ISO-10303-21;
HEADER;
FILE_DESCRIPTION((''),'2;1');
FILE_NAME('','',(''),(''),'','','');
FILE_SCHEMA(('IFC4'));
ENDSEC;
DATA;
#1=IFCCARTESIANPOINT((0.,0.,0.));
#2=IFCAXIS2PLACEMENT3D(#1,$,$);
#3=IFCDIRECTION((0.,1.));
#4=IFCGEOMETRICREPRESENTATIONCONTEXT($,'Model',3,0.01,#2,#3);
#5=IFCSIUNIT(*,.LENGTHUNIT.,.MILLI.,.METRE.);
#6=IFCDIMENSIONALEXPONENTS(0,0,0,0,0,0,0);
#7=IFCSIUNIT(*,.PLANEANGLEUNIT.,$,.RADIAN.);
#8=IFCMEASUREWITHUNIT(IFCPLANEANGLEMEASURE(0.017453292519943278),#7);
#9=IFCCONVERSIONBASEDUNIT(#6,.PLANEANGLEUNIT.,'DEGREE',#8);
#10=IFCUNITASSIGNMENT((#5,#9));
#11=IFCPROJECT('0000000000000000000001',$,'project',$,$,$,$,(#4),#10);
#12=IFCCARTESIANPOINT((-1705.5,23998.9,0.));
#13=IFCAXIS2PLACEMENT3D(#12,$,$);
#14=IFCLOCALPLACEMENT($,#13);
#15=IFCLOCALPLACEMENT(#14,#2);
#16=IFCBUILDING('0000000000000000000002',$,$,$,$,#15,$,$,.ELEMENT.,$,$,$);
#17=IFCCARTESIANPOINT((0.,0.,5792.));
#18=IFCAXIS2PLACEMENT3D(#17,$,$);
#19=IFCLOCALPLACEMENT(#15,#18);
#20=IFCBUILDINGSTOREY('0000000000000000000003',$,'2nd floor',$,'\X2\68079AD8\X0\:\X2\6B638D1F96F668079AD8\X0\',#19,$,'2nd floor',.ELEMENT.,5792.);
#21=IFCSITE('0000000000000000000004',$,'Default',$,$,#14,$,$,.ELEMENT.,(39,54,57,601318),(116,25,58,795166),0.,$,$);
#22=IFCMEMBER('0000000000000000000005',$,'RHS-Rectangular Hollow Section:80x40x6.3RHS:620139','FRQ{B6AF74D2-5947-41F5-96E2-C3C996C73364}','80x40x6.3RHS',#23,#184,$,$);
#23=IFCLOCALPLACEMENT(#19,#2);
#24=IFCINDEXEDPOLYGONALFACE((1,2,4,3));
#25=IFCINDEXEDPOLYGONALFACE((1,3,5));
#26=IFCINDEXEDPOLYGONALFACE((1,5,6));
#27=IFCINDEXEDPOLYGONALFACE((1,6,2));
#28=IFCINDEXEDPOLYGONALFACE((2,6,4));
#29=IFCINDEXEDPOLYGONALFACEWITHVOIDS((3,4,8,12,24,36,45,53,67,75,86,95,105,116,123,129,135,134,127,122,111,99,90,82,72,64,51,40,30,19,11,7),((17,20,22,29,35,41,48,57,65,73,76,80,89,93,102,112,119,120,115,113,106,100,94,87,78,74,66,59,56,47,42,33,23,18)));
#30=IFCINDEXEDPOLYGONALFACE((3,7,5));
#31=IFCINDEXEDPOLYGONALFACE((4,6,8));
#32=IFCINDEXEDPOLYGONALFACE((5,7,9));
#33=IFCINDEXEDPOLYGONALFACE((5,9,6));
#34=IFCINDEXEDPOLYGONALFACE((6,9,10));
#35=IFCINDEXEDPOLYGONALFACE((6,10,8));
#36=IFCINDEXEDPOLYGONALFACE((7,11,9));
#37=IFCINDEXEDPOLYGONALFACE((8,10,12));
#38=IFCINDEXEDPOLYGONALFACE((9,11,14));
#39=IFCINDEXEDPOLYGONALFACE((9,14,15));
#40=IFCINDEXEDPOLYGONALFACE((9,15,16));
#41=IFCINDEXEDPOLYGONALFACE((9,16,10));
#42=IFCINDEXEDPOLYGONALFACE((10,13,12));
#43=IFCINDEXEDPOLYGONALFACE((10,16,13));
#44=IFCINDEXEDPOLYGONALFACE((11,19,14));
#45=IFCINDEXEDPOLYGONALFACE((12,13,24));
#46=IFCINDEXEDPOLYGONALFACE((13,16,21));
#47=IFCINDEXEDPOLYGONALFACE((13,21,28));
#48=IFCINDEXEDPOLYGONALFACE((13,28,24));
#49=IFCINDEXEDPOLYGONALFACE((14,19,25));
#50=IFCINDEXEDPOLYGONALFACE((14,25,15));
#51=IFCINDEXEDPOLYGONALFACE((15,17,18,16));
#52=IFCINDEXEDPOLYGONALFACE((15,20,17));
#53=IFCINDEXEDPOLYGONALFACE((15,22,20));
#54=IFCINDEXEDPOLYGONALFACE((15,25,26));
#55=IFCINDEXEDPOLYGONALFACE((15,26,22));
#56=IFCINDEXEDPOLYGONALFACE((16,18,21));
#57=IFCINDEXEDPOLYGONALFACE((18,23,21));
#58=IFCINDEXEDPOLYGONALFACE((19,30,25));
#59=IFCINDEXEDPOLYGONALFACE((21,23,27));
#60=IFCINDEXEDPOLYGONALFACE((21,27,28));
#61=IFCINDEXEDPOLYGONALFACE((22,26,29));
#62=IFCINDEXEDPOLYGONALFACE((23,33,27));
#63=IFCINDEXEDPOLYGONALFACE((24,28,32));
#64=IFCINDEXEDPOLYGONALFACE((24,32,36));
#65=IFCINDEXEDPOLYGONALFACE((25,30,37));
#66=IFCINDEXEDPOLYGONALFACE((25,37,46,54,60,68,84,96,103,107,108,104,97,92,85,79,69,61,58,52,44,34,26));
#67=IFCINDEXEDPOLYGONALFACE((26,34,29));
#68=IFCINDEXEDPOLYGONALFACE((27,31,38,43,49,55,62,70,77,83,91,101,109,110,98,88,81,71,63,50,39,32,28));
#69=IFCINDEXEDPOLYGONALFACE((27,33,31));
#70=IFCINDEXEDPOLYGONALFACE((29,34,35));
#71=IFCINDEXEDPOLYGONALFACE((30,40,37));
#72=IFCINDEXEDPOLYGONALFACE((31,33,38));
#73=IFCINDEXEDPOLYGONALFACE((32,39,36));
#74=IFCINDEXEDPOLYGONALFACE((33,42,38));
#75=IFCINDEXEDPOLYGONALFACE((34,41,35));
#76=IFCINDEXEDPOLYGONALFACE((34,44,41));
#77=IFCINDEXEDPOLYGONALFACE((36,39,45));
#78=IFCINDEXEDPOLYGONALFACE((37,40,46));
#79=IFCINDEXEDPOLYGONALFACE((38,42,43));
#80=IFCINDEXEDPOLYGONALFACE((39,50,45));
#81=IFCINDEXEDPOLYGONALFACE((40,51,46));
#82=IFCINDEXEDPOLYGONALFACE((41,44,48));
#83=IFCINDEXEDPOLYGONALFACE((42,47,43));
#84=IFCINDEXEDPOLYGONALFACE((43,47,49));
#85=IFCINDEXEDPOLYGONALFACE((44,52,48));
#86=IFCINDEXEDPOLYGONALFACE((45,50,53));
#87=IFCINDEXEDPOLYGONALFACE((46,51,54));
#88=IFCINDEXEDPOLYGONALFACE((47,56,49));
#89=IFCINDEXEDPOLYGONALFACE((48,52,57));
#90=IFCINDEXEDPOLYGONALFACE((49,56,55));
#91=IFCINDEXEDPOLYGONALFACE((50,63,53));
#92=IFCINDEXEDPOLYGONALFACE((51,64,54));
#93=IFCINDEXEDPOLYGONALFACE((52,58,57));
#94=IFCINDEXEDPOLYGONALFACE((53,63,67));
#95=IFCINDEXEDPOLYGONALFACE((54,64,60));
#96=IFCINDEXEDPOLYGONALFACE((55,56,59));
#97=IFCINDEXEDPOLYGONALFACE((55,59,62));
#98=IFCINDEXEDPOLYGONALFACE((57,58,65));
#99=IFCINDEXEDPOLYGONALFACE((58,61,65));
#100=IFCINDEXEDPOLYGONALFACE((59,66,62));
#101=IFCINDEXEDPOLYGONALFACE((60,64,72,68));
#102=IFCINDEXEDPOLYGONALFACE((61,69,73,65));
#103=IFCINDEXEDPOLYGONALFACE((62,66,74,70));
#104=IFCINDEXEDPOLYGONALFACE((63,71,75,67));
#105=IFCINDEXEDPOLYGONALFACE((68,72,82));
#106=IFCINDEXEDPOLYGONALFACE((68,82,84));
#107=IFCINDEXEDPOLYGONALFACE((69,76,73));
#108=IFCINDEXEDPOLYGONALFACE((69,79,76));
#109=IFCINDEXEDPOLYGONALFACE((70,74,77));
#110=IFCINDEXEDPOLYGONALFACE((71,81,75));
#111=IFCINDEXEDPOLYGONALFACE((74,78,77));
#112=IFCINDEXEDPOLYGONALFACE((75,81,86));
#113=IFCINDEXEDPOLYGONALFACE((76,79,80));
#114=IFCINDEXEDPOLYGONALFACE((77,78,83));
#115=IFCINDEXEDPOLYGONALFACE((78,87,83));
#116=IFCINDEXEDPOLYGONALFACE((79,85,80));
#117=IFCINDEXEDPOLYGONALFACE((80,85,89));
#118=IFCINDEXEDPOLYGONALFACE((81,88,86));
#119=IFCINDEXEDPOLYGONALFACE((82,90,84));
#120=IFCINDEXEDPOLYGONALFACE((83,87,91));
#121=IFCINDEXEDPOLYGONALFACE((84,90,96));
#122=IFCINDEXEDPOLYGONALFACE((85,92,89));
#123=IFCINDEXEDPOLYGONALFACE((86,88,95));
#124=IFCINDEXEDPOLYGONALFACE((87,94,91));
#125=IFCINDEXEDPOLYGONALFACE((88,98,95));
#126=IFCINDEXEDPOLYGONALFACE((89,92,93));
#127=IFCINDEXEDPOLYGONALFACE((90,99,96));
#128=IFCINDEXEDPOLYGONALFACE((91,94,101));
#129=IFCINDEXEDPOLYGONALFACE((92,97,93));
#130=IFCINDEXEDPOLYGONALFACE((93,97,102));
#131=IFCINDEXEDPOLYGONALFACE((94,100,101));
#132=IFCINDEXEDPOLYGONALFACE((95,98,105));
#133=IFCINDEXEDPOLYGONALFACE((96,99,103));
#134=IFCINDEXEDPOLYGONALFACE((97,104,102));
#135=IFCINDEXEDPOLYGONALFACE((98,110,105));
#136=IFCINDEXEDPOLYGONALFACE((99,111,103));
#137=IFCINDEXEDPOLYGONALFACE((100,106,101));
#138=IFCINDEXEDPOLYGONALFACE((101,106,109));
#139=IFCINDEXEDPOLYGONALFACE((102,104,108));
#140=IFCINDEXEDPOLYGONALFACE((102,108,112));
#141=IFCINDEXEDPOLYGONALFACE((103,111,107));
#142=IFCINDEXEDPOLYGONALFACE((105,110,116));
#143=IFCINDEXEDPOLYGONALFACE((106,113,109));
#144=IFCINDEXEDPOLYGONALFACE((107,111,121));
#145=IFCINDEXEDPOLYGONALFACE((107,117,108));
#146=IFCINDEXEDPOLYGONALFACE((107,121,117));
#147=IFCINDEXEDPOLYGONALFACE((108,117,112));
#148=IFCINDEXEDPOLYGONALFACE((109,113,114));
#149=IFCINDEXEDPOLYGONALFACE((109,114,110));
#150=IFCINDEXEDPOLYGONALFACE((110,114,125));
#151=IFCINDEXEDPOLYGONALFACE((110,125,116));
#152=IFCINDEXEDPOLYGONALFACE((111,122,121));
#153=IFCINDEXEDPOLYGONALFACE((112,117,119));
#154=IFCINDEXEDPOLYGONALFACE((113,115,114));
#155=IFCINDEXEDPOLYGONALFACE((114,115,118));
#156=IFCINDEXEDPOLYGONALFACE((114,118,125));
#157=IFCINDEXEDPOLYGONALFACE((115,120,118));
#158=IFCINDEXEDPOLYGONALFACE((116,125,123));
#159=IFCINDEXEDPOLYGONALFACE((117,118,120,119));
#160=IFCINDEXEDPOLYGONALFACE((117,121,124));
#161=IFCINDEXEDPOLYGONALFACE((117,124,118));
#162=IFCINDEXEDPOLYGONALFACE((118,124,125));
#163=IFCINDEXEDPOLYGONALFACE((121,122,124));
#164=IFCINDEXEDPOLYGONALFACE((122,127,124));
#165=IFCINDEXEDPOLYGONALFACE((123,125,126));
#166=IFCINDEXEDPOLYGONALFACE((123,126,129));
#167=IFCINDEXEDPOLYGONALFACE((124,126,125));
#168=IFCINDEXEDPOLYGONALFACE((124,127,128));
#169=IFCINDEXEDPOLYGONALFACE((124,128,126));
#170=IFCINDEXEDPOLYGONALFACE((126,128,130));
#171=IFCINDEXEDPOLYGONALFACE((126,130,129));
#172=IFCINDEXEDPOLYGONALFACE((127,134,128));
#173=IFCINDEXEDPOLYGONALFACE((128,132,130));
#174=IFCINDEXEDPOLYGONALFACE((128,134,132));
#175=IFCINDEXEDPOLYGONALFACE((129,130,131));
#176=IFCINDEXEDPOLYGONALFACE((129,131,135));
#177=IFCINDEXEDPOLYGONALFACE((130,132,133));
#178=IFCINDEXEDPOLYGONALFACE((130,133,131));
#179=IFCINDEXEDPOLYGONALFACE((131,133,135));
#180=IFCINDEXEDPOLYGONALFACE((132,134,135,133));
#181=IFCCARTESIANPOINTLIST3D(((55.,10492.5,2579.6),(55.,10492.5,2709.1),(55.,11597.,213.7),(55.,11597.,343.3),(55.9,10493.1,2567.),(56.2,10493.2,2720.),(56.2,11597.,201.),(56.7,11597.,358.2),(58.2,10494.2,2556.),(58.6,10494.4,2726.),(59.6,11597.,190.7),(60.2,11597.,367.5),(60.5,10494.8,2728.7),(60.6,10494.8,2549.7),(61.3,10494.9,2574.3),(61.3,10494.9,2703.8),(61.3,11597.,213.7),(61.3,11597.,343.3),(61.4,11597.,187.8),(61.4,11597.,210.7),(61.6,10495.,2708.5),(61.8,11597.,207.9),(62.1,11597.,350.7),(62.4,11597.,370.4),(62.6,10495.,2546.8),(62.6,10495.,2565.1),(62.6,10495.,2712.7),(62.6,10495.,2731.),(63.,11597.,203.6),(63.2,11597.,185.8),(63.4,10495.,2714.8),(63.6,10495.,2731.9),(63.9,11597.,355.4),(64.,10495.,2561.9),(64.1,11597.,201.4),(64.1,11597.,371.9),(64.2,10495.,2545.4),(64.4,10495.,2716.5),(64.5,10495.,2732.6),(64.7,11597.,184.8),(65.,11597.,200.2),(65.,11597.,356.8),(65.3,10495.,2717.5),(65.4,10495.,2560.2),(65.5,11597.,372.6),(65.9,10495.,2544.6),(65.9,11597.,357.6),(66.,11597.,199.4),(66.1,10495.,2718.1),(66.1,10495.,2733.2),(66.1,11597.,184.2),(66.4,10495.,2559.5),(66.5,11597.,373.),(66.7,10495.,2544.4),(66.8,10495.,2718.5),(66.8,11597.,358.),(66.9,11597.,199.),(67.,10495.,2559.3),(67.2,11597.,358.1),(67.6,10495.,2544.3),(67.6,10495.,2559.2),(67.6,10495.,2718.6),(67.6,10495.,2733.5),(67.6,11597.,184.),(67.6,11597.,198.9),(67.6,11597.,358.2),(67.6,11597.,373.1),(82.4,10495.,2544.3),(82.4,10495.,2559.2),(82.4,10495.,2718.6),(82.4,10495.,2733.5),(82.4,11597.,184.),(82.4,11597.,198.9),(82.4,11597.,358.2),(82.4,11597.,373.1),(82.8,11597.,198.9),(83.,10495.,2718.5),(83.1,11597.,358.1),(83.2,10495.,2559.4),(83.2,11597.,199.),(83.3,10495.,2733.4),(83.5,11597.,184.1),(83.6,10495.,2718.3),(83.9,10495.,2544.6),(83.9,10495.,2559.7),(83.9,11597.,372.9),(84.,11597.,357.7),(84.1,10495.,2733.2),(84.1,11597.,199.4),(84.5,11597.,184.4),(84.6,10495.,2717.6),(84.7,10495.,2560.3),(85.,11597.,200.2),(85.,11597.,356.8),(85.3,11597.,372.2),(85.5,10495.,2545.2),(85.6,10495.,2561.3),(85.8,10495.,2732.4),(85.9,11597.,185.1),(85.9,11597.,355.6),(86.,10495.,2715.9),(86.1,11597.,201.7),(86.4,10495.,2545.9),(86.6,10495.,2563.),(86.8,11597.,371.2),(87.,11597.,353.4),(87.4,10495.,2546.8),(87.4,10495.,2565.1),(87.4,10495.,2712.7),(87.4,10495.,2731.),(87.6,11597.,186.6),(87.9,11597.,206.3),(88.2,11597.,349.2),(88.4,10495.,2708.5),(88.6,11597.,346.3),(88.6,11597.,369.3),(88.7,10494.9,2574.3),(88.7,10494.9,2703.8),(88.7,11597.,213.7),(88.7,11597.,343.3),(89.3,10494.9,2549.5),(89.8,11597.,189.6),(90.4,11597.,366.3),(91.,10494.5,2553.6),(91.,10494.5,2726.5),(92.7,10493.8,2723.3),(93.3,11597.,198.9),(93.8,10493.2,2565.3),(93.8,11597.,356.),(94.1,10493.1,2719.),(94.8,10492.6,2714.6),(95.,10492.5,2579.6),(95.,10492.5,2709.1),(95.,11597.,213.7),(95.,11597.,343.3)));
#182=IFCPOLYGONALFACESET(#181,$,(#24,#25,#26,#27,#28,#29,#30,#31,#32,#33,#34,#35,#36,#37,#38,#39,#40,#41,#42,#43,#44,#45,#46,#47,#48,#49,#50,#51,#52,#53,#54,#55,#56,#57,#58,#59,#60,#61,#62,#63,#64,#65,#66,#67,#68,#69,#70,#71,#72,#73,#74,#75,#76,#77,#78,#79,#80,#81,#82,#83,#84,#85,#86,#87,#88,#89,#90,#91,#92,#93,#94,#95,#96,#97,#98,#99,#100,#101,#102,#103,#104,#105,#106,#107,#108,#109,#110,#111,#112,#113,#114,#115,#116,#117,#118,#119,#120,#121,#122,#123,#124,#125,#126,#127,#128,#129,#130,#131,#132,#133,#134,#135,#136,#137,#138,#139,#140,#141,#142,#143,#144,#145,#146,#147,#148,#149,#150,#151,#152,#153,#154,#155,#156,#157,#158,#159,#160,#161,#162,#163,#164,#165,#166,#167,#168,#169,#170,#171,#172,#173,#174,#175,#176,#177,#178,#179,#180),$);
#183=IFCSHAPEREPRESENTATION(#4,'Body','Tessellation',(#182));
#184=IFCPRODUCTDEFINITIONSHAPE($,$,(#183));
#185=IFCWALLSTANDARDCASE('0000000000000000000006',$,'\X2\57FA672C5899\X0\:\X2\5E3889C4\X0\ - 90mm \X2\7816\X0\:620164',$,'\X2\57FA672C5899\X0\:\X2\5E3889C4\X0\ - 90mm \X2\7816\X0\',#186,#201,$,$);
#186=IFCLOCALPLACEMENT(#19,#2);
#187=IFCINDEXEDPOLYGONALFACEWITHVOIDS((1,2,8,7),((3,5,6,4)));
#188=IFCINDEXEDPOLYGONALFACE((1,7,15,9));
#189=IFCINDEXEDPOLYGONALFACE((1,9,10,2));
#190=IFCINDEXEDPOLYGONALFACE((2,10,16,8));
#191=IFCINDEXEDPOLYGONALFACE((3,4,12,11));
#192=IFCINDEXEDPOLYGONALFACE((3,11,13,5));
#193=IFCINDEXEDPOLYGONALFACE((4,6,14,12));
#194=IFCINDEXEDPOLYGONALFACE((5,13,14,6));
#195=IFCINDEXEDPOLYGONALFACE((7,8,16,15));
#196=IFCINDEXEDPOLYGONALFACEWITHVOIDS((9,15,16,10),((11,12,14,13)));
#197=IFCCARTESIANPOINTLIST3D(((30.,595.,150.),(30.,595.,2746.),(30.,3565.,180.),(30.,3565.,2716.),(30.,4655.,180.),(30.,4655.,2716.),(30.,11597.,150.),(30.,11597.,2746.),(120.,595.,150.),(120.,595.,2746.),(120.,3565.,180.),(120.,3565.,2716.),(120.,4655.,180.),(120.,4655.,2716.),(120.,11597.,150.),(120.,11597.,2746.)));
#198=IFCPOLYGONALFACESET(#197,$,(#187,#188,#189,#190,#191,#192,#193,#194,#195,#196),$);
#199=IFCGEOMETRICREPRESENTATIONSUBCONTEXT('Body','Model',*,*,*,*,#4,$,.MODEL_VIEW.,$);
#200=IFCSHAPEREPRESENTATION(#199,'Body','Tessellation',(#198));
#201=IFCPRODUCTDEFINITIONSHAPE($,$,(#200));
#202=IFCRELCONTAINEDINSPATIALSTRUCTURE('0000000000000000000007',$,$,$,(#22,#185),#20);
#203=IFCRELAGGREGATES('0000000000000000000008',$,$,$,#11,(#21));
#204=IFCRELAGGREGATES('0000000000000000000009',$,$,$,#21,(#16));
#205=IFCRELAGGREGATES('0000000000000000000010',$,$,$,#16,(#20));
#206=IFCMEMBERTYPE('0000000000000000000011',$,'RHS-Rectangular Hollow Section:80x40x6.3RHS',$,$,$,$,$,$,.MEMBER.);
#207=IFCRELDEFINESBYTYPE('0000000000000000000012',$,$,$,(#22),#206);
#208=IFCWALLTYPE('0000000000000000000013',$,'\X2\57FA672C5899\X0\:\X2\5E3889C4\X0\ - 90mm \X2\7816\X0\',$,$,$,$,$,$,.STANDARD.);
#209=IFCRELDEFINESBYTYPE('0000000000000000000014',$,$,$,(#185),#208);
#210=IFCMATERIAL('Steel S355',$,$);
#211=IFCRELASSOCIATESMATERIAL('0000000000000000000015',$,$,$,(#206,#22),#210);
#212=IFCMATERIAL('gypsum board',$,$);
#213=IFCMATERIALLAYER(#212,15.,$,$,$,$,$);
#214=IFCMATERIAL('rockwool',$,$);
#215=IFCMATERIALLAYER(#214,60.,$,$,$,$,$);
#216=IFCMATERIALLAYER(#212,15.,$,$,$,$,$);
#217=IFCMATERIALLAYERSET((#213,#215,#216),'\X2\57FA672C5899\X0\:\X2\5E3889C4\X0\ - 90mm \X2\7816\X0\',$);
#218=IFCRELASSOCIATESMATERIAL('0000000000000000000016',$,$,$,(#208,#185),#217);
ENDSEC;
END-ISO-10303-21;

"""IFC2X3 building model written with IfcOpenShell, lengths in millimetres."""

from ifc_helpers import new_model, entity, si_unit, converted_unit, point, direction, frame, frame_2d, origin, origin_2d, place, context, subcontext, project, spatial, circle_curve, line_curve, trimmed, segment, composite_curve, rectangle, hollow_rectangle, outline, extrude, clip, halfspace, material, layer, layer_set, layer_usage, type_object, element, save


model = new_model("IFC2X3")

# Units and contexts
model_context = context("Model", 3, precision=0.01, world=origin(), true_north=direction((0.0, 1.0)))
body_context = subcontext(model_context, "Body", "Model", "MODEL_VIEW")
ifc_project = project(units=[si_unit("LENGTHUNIT", "METRE", prefix="MILLI"), converted_unit("PLANEANGLEUNIT", "DEGREE", entity("IfcPlaneAngleMeasure", 0.017453292519943278), si_unit("PLANEANGLEUNIT", "RADIAN"), dimensions=[0, 0, 0, 0, 0, 0, 0])], contexts=[model_context])

# Site, building, storey
site_placement = place(None, frame((-1705.5, 23998.9, 0.0)))
site = spatial("IfcSite", under=ifc_project, at=site_placement, Name="Default", CompositionType="ELEMENT", RefLatitude=(39, 54, 57, 601318), RefLongitude=(116, 25, 58, 795166), RefElevation=0.0)
building_placement = place(site_placement, origin())
building = spatial("IfcBuilding", under=site, at=building_placement, CompositionType="ELEMENT")
storey_placement = place(building_placement, frame((0.0, 0.0, 5792.0)))
storey = spatial("IfcBuildingStorey", under=building, at=storey_placement, Name="2nd floor", ObjectType="标高:正负零标高", LongName="2nd floor", CompositionType="ELEMENT", Elevation=5792.0)

# Shared definitions
ifc_material_1 = material(Name="Steel S355")

# Member, openings
member_type_1 = type_object("IfcMemberType", Name="RHS-Rectangular Hollow Section:80x40x6.3RHS", PredefinedType="MEMBER", material=ifc_material_1)
member_1_placement = place(storey_placement, frame((75.0, 11701.7, 54.2), z_axis=(0.0, 0.423038, -0.906112), x_axis=(-1.0, 0.0, 0.0)))
member_1 = element("IfcMember", 1, at=member_1_placement, inside=storey, type_object=member_type_1, material=ifc_material_1, Name="RHS-Rectangular Hollow Section:80x40x6.3RHS:620139", Description="FRQ{B6AF74D2-5947-41F5-96E2-C3C996C73364}", ObjectType="80x40x6.3RHS", context=model_context, shape_type="Clipping", body=[
    clip(clip(extrude(hollow_rectangle(XDim=40.0, YDim=80.0, WallThickness=6.3, InnerFilletRadius=6.3, OuterFilletRadius=12.6, at=origin_2d()), origin(), (0.0, 0.0, -1.0), 3076.4), halfspace(frame((75.0, -2513.7, 5278.4), z_axis=(0.0, -0.906112, -0.423038), x_axis=(-1.0, 0.0, 0.0)), True)), halfspace(frame((75.0, -3611.9, 4765.7), z_axis=(0.0, 0.906112, 0.423038), x_axis=(1.0, 0.0, 0.0)), True)),
])
opening_1_placement = place(member_1_placement, frame((0.0, -82.3, 70.7), z_axis=(0.0, 0.423038, -0.906112), x_axis=(-1.0, 0.0, 0.0)))
element("IfcOpeningElement", 2, at=opening_1_placement, cuts=member_1, ObjectType="Opening", context=model_context, shape_type="SweptSolid", body=[
    extrude(outline(composite_curve([segment(trimmed(circle_curve(frame_2d((-40.0, -40.0), x_axis=(1.0, 0.0)), 20.0), [point((-60.0, -40.0))], [point((-40.0, -60.0))], True, "CARTESIAN"), True, "CONTINUOUS"), segment(trimmed(line_curve((-40.0, -60.0), (1.0, 0.0), 79.999999), [point((-40.0, -60.0))], [point((40.0, -60.0))], True, "CARTESIAN"), True, "CONTINUOUS"), segment(trimmed(circle_curve(frame_2d((40.0, -40.0), x_axis=(1.0, 0.0)), 20.0), [point((40.0, -60.0))], [point((60.0, -40.0))], True, "CARTESIAN"), True, "CONTINUOUS"), segment(trimmed(line_curve((60.0, -40.0), (0.0, 1.0), 79.999999), [point((60.0, -40.0))], [point((60.0, 40.0))], True, "CARTESIAN"), True, "CONTINUOUS"), segment(trimmed(circle_curve(frame_2d((40.0, 40.0), x_axis=(1.0, 0.0)), 20.0), [point((60.0, 40.0))], [point((40.0, 60.0))], True, "CARTESIAN"), True, "CONTINUOUS"), segment(trimmed(line_curve((40.0, 60.0), (-1.0, 0.0), 80.0), [point((40.0, 60.0))], [point((-40.0, 60.0))], True, "CARTESIAN"), True, "CONTINUOUS"), segment(trimmed(circle_curve(frame_2d((-40.0, 40.0), x_axis=(1.0, 0.0)), 20.0), [point((-40.0, 60.0))], [point((-60.0, 40.0))], True, "CARTESIAN"), True, "CONTINUOUS"), segment(trimmed(line_curve((-60.0, 40.0), (0.0, -1.0), 80.0), [point((-60.0, 40.0))], [point((-60.0, -40.0))], True, "CARTESIAN"), True, "CONTINUOUS")], self_intersect="UNKNOWN")), origin(), (0.0, 0.0, 1.0), 2985.3),
])
opening_2_placement = place(member_1_placement, frame((0.0, -82.3, 70.7), z_axis=(0.0, 0.423038, -0.906112), x_axis=(-1.0, 0.0, 0.0)))
element("IfcOpeningElement", 3, at=opening_2_placement, cuts=member_1, ObjectType="Opening", context=model_context, shape_type="SweptSolid", body=[
    extrude(outline(composite_curve([segment(trimmed(circle_curve(frame_2d((-12.4, -1174.6), x_axis=(1.0, 0.0)), 12.6), [point((-12.4, -1162.0))], [point((-25.0, -1174.6))], True, "CARTESIAN"), True, "CONTINUOUS"), segment(trimmed(line_curve((-25.0, -1174.6), (0.0, -1.0), 74.800002), [point((-25.0, -1174.6))], [point((-25.0, -1249.4))], True, "CARTESIAN"), True, "CONTINUOUS"), segment(trimmed(circle_curve(frame_2d((-12.4, -1249.4), x_axis=(1.0, 0.0)), 12.6), [point((-25.0, -1249.4))], [point((-12.4, -1262.0))], True, "CARTESIAN"), True, "CONTINUOUS"), segment(trimmed(line_curve((-12.4, -1262.0), (1.0, 0.0), 24.800002), [point((-12.4, -1262.0))], [point((12.4, -1262.0))], True, "CARTESIAN"), True, "CONTINUOUS"), segment(trimmed(circle_curve(frame_2d((12.4, -1249.4), x_axis=(1.0, 0.0)), 12.6), [point((12.4, -1262.0))], [point((25.0, -1249.4))], True, "CARTESIAN"), True, "CONTINUOUS"), segment(trimmed(line_curve((25.0, -1249.4), (0.0, 1.0), 74.800002), [point((25.0, -1249.4))], [point((25.0, -1174.6))], True, "CARTESIAN"), True, "CONTINUOUS"), segment(trimmed(circle_curve(frame_2d((12.4, -1174.6), x_axis=(1.0, 0.0)), 12.6), [point((25.0, -1174.6))], [point((12.4, -1162.0))], True, "CARTESIAN"), True, "CONTINUOUS"), segment(trimmed(line_curve((12.4, -1162.0), (-1.0, 0.0), 24.800002), [point((12.4, -1162.0))], [point((-12.4, -1162.0))], True, "CARTESIAN"), True, "CONTINUOUS")], self_intersect="UNKNOWN")), origin(), (0.0, 0.0, 1.0), 2985.3),
])

# Shared definitions
ifc_material_2 = material(Name="gypsum board")
ifc_layer_1 = layer(ifc_material_2, 15.0)
ifc_material_3 = material(Name="rockwool")
ifc_layer_2 = layer(ifc_material_3, 60.0)
ifc_layer_3 = layer(ifc_material_2, 15.0)
ifc_layer_set = layer_set([ifc_layer_1, ifc_layer_2, ifc_layer_3], Name="基本墙:常规 - 90mm 砖")
wall_type = type_object("IfcWallType", Name="基本墙:常规 - 90mm 砖", PredefinedType="STANDARD", material=ifc_layer_set)

# Wall, opening
ifc_layer_usage_1 = layer_usage(ifc_layer_set, "AXIS2", "NEGATIVE", 45.0)
wall_1_placement = place(storey_placement, frame((75.0, 11597.0, 150.0), z_axis=(0.0, 0.0, 1.0), x_axis=(0.0, -1.0, 0.0)))
wall_1 = element("IfcWallStandardCase", 4, at=wall_1_placement, inside=storey, type_object=wall_type, material=ifc_layer_usage_1, Name="基本墙:常规 - 90mm 砖:620164", ObjectType="基本墙:常规 - 90mm 砖", context=body_context, shape_type="SweptSolid", body=[
    extrude(rectangle(XDim=11002.0, YDim=90.0, at=frame_2d((5501.0, 0.0), x_axis=(-1.0, 0.0))), origin(), (0.0, 0.0, 1.0), 2596.0),
])
opening_3_placement = place(wall_1_placement, origin())
element("IfcOpeningElement", 5, at=opening_3_placement, cuts=wall_1, ObjectType="Opening", context=body_context, shape_type="SweptSolid", body=[
    extrude(rectangle(XDim=2536.0, YDim=1090.0, at=frame_2d((0.0, 0.0), x_axis=(0.0, 1.0))), frame((7487.0, 45.0, 1298.0), z_axis=(0.0, -1.0, 0.0), x_axis=(-1.0, 0.0, 0.0)), (0.0, 0.0, 1.0), 90.0),
])

save(model, "model.ifc")
